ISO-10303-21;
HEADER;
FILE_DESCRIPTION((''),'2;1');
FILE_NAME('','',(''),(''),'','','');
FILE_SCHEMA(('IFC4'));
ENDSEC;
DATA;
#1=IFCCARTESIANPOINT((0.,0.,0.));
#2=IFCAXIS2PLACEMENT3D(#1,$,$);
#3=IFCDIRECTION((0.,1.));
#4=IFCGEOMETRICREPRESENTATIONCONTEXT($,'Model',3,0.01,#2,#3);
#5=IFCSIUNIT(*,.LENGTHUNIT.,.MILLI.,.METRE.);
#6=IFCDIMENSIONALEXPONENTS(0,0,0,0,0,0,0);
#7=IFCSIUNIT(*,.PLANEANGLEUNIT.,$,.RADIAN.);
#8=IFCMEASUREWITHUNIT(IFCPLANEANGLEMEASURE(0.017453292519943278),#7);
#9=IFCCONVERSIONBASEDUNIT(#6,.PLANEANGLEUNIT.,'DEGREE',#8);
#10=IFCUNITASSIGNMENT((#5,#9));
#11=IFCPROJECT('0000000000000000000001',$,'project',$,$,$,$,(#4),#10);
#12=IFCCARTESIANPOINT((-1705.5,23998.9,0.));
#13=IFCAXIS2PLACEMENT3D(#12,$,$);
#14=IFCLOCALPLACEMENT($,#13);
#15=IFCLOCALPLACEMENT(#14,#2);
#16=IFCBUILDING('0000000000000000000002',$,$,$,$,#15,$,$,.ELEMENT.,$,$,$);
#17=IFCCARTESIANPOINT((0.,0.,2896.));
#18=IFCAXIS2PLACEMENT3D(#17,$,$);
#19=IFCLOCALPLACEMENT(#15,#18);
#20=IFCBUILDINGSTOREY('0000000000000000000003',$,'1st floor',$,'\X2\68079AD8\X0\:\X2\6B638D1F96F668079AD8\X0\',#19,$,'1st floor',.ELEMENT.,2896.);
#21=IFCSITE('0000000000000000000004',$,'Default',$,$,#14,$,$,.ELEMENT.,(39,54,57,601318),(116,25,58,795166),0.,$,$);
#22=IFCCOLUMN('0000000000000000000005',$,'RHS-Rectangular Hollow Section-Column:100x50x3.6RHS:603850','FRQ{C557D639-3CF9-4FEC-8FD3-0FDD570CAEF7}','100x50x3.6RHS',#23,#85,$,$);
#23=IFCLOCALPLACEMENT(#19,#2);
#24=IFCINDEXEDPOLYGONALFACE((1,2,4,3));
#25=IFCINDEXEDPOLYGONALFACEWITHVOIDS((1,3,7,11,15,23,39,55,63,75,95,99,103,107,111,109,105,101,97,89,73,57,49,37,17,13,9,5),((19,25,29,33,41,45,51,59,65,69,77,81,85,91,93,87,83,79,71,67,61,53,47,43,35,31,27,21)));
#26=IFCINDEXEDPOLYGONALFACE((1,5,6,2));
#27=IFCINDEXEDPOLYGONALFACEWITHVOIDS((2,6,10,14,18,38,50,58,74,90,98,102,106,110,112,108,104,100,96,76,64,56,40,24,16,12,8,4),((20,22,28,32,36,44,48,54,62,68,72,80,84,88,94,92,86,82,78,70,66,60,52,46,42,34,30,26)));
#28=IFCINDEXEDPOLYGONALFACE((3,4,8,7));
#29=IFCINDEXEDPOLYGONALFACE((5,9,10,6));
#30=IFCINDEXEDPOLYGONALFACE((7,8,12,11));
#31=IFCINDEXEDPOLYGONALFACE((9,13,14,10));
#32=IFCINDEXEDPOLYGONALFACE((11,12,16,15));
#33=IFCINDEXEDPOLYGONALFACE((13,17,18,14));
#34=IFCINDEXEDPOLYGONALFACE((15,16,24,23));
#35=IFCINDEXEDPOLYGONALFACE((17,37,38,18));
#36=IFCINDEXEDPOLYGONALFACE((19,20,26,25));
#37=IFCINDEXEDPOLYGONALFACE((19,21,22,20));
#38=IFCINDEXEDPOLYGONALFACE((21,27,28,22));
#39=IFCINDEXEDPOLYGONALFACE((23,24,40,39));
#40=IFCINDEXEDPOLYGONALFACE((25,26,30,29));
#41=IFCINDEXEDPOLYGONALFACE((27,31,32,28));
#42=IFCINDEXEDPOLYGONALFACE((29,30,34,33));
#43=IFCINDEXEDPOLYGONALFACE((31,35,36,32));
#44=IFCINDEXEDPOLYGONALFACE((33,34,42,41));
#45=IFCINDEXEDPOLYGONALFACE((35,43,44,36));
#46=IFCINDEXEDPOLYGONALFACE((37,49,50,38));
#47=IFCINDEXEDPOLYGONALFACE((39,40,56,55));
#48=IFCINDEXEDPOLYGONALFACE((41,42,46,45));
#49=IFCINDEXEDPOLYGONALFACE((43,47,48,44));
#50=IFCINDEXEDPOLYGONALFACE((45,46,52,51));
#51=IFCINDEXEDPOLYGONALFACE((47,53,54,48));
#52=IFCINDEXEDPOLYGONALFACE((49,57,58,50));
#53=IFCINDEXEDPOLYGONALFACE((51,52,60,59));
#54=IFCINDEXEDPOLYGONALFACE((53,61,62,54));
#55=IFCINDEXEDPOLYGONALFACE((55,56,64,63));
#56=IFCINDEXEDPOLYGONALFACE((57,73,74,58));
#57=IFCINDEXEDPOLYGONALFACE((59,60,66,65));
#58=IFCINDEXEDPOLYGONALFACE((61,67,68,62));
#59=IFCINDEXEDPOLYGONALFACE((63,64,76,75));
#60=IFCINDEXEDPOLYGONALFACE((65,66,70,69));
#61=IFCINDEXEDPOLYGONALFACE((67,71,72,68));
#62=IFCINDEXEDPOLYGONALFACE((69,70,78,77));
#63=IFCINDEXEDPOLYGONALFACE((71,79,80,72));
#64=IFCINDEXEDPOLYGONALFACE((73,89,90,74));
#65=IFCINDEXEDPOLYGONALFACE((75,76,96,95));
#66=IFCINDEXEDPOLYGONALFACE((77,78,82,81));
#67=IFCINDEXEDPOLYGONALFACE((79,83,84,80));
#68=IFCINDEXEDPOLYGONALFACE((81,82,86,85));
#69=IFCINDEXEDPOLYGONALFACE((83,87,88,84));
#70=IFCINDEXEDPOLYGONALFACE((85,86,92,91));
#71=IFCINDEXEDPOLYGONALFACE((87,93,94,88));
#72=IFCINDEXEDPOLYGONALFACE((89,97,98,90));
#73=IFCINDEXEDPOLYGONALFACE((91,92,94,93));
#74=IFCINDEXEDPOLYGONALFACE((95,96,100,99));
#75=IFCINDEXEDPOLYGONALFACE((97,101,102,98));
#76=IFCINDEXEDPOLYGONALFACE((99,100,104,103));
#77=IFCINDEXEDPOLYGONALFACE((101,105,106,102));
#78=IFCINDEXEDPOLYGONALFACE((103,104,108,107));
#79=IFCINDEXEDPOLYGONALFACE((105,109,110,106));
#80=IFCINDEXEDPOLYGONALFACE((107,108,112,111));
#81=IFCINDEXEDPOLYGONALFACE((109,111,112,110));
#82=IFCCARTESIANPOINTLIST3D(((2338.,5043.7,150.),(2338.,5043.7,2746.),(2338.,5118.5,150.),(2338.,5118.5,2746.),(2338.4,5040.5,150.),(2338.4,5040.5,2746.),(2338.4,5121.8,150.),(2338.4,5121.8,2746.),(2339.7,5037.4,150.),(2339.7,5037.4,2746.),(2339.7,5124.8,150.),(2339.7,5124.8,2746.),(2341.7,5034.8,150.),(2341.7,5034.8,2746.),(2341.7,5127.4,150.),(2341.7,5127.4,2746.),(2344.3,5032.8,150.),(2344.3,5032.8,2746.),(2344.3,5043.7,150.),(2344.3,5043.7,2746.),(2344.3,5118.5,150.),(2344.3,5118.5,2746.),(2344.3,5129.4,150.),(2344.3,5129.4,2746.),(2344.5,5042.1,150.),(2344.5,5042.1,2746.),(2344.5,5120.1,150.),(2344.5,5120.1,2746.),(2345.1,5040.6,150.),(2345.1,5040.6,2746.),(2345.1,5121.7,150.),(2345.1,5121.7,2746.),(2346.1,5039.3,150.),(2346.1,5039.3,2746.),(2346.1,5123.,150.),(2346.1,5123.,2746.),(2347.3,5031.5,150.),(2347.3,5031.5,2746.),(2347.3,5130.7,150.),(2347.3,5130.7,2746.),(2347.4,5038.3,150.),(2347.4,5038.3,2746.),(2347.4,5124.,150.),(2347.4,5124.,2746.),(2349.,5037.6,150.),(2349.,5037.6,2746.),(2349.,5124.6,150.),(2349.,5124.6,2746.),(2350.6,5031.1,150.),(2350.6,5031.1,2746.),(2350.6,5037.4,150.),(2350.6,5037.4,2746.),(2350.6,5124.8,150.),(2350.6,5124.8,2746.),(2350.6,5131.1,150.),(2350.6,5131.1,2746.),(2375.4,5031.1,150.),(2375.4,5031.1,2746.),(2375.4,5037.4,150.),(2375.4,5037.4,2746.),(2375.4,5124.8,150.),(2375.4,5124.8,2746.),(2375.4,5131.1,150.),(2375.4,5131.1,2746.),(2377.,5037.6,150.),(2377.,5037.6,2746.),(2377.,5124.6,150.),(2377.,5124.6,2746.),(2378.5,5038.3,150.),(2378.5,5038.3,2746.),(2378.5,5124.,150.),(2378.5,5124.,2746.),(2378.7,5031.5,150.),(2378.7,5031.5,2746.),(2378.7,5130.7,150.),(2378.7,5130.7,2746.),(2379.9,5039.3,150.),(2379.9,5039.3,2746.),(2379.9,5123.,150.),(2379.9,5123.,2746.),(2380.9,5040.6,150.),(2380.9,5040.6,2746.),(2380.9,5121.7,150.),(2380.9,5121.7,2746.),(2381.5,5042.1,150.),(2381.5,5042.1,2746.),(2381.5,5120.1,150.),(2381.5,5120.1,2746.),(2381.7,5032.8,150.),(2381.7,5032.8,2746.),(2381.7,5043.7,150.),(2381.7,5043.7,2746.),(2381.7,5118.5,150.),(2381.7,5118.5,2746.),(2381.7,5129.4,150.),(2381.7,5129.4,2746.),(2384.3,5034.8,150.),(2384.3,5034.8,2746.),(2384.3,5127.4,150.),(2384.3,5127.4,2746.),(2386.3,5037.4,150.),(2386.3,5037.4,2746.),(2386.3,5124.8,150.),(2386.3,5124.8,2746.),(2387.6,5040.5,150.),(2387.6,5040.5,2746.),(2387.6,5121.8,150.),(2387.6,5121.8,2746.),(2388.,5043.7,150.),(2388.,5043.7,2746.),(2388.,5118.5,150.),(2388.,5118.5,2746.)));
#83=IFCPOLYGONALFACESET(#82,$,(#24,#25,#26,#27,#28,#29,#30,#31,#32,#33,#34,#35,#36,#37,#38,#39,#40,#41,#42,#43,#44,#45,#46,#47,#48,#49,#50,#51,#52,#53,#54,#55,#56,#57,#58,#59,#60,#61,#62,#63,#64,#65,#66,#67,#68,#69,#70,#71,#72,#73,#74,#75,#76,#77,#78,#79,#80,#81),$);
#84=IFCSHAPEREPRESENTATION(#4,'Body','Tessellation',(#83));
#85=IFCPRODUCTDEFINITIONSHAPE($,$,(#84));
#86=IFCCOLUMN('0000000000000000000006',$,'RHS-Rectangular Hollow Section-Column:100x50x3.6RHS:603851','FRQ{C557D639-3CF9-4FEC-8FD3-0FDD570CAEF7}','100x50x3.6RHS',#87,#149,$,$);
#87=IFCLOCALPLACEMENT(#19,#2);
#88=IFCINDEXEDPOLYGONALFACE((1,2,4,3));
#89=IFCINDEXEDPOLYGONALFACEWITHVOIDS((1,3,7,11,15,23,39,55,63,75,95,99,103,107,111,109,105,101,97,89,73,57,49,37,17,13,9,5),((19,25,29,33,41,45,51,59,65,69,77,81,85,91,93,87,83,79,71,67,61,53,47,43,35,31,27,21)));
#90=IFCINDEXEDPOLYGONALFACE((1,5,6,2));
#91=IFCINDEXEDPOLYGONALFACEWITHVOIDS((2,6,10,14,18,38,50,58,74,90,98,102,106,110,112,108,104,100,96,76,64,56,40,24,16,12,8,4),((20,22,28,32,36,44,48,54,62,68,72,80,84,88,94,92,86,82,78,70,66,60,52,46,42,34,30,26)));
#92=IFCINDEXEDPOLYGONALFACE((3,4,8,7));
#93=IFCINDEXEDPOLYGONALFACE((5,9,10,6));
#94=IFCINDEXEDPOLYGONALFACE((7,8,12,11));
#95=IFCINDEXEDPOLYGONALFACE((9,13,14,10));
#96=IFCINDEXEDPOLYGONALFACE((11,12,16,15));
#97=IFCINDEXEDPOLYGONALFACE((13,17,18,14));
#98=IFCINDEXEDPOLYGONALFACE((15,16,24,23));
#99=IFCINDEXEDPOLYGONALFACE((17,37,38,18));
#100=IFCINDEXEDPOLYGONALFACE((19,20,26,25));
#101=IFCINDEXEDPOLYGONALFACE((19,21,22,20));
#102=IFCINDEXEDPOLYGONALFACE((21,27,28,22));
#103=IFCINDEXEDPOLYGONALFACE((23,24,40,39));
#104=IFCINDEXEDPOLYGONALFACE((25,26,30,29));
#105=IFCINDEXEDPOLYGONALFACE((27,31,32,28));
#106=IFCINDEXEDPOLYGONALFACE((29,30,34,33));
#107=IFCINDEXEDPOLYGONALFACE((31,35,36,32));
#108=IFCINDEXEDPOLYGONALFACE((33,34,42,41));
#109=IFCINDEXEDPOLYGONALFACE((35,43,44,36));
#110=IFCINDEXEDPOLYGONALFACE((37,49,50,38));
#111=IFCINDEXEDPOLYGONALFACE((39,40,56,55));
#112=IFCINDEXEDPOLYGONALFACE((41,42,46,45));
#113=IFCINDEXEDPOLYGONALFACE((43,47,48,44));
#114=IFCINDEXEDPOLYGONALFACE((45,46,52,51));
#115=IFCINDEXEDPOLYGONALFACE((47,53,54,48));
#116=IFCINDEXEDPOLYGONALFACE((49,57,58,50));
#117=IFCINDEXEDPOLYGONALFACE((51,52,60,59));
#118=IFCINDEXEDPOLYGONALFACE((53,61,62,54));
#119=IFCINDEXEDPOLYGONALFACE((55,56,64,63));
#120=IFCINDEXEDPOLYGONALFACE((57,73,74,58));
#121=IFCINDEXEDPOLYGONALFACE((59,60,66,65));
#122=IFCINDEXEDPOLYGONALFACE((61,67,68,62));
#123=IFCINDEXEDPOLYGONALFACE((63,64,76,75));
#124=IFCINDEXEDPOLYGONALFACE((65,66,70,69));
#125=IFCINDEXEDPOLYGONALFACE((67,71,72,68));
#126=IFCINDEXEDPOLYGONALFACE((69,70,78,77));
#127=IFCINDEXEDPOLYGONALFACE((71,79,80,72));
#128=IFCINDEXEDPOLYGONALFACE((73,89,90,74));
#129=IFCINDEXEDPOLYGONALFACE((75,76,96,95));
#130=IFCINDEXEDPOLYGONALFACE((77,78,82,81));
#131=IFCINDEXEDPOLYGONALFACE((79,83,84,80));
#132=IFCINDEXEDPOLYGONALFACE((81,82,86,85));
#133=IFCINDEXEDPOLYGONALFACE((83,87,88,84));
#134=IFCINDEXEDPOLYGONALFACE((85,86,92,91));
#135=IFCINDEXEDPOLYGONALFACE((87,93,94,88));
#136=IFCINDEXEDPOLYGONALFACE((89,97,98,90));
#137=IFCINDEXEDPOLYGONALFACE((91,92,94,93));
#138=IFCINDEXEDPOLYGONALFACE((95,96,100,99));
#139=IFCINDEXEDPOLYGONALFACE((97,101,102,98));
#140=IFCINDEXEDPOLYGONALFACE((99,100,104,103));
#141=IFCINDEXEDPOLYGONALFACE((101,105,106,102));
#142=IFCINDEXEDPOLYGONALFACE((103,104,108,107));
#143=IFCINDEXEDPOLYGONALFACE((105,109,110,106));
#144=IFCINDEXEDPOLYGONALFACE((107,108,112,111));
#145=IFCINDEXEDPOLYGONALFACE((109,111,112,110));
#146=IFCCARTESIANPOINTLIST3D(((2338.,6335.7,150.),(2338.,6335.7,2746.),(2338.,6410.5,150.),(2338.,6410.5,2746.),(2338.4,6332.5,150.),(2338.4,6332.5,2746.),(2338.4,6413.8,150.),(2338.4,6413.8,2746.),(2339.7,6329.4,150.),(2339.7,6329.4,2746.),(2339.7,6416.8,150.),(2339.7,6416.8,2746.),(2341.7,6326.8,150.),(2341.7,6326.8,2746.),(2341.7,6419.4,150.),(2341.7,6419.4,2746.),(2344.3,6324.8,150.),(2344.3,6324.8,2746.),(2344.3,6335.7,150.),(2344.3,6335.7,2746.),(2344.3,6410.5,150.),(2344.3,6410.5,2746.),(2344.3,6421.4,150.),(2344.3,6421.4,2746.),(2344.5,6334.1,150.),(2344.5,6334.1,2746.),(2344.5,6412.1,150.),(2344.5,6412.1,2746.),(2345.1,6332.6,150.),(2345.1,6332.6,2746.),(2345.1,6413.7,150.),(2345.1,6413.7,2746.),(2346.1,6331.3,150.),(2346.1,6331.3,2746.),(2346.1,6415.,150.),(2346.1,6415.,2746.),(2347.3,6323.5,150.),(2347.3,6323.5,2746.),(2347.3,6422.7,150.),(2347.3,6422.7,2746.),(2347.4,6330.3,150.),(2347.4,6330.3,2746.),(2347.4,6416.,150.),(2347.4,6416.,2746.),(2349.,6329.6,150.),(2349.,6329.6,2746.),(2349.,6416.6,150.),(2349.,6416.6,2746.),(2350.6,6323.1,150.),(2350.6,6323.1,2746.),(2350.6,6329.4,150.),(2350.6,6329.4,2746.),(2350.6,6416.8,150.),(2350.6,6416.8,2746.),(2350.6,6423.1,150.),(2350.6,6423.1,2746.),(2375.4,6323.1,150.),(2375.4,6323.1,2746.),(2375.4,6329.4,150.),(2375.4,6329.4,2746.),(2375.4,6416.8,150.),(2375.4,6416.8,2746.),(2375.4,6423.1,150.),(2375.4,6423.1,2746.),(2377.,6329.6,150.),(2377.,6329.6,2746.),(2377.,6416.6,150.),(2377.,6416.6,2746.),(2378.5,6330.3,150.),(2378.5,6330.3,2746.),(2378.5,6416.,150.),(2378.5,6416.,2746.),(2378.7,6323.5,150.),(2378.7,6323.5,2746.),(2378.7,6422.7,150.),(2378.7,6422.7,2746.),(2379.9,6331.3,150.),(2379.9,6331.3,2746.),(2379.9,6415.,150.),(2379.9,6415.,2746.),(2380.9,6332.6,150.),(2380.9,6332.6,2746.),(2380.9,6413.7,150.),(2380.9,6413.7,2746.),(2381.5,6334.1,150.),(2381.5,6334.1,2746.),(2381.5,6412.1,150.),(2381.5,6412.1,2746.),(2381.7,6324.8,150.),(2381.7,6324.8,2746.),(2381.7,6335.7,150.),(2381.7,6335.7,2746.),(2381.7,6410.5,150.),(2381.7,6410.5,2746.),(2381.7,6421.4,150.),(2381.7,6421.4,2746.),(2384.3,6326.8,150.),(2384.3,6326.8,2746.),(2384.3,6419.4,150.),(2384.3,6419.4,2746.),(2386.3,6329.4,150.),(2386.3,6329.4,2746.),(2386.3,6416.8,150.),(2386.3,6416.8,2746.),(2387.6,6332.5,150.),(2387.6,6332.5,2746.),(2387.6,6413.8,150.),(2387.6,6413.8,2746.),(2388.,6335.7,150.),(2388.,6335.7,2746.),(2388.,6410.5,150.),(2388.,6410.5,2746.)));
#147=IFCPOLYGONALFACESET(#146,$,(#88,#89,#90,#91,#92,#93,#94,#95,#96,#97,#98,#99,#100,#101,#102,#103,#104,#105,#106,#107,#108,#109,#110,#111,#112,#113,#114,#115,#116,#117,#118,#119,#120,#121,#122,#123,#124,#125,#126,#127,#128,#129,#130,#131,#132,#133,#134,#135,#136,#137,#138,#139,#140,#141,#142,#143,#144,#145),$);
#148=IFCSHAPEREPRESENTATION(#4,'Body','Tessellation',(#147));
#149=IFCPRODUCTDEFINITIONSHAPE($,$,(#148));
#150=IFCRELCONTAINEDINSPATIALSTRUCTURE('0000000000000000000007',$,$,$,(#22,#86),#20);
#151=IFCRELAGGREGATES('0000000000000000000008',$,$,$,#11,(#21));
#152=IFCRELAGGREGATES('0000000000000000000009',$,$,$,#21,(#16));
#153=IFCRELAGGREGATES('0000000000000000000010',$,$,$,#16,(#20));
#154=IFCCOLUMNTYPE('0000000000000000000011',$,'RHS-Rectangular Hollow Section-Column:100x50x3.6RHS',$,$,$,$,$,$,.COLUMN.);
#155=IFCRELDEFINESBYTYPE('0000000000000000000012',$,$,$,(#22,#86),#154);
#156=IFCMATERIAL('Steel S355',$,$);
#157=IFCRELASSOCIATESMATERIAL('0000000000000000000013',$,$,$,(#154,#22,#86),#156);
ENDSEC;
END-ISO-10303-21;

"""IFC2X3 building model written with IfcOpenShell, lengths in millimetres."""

from ifc_helpers import new_model, entity, si_unit, converted_unit, direction, frame, origin, origin_2d, place, context, project, spatial, hollow_rectangle, extrude, clip, halfspace, material, type_object, element, save


model = new_model("IFC2X3")

# Units and contexts
model_context = context("Model", 3, precision=0.01, world=origin(), true_north=direction((0.0, 1.0)))
ifc_project = project(units=[si_unit("LENGTHUNIT", "METRE", prefix="MILLI"), converted_unit("PLANEANGLEUNIT", "DEGREE", entity("IfcPlaneAngleMeasure", 0.017453292519943278), si_unit("PLANEANGLEUNIT", "RADIAN"), dimensions=[0, 0, 0, 0, 0, 0, 0])], contexts=[model_context])

# Site, building, storey
site_placement = place(None, frame((-1705.5, 23998.9, 0.0)))
site = spatial("IfcSite", under=ifc_project, at=site_placement, Name="Default", CompositionType="ELEMENT", RefLatitude=(39, 54, 57, 601318), RefLongitude=(116, 25, 58, 795166), RefElevation=0.0)
building_placement = place(site_placement, origin())
building = spatial("IfcBuilding", under=site, at=building_placement, CompositionType="ELEMENT")
storey_placement = place(building_placement, frame((0.0, 0.0, 2896.0)))
storey = spatial("IfcBuildingStorey", under=building, at=storey_placement, Name="1st floor", ObjectType="标高:正负零标高", LongName="1st floor", CompositionType="ELEMENT", Elevation=2896.0)

# Shared definitions
ifc_material_1 = material(Name="Steel S355")
column_type = type_object("IfcColumnType", Name="RHS-Rectangular Hollow Section-Column:100x50x3.6RHS", PredefinedType="COLUMN", material=ifc_material_1)

# Columns
column_1_placement = place(storey_placement, frame((2363.0, 5081.1, 2746.0), z_axis=(0.0, 0.0, 1.0), x_axis=(-1.0, 0.0, 0.0)))
element("IfcColumn", 1, at=column_1_placement, inside=storey, type_object=column_type, material=ifc_material_1, Name="RHS-Rectangular Hollow Section-Column:100x50x3.6RHS:603850", Description="FRQ{C557D639-3CF9-4FEC-8FD3-0FDD570CAEF7}", ObjectType="100x50x3.6RHS", context=model_context, shape_type="Clipping", body=[
    clip(extrude(hollow_rectangle(XDim=50.0, YDim=100.0, WallThickness=6.3, InnerFilletRadius=6.3, OuterFilletRadius=12.6, at=origin_2d()), origin(), (0.0, 0.0, -1.0), 2651.9), halfspace(frame((2363.0, 5081.1, -2596.0), z_axis=(0.0, 0.0, 1.0), x_axis=(-1.0, 0.0, 0.0)), True)),
])
column_2_placement = place(storey_placement, frame((2363.0, 6373.1, 2746.0), z_axis=(0.0, 0.0, 1.0), x_axis=(-1.0, 0.0, 0.0)))
element("IfcColumn", 2, at=column_2_placement, inside=storey, type_object=column_type, material=ifc_material_1, Name="RHS-Rectangular Hollow Section-Column:100x50x3.6RHS:603851", Description="FRQ{C557D639-3CF9-4FEC-8FD3-0FDD570CAEF7}", ObjectType="100x50x3.6RHS", context=model_context, shape_type="Clipping", body=[
    clip(extrude(hollow_rectangle(XDim=50.0, YDim=100.0, WallThickness=6.3, InnerFilletRadius=6.3, OuterFilletRadius=12.6, at=origin_2d()), origin(), (0.0, 0.0, -1.0), 2651.9), halfspace(frame((2363.0, 6373.1, -2596.0), z_axis=(0.0, 0.0, 1.0), x_axis=(-1.0, 0.0, 0.0)), True)),
])

save(model, "model.ifc")
